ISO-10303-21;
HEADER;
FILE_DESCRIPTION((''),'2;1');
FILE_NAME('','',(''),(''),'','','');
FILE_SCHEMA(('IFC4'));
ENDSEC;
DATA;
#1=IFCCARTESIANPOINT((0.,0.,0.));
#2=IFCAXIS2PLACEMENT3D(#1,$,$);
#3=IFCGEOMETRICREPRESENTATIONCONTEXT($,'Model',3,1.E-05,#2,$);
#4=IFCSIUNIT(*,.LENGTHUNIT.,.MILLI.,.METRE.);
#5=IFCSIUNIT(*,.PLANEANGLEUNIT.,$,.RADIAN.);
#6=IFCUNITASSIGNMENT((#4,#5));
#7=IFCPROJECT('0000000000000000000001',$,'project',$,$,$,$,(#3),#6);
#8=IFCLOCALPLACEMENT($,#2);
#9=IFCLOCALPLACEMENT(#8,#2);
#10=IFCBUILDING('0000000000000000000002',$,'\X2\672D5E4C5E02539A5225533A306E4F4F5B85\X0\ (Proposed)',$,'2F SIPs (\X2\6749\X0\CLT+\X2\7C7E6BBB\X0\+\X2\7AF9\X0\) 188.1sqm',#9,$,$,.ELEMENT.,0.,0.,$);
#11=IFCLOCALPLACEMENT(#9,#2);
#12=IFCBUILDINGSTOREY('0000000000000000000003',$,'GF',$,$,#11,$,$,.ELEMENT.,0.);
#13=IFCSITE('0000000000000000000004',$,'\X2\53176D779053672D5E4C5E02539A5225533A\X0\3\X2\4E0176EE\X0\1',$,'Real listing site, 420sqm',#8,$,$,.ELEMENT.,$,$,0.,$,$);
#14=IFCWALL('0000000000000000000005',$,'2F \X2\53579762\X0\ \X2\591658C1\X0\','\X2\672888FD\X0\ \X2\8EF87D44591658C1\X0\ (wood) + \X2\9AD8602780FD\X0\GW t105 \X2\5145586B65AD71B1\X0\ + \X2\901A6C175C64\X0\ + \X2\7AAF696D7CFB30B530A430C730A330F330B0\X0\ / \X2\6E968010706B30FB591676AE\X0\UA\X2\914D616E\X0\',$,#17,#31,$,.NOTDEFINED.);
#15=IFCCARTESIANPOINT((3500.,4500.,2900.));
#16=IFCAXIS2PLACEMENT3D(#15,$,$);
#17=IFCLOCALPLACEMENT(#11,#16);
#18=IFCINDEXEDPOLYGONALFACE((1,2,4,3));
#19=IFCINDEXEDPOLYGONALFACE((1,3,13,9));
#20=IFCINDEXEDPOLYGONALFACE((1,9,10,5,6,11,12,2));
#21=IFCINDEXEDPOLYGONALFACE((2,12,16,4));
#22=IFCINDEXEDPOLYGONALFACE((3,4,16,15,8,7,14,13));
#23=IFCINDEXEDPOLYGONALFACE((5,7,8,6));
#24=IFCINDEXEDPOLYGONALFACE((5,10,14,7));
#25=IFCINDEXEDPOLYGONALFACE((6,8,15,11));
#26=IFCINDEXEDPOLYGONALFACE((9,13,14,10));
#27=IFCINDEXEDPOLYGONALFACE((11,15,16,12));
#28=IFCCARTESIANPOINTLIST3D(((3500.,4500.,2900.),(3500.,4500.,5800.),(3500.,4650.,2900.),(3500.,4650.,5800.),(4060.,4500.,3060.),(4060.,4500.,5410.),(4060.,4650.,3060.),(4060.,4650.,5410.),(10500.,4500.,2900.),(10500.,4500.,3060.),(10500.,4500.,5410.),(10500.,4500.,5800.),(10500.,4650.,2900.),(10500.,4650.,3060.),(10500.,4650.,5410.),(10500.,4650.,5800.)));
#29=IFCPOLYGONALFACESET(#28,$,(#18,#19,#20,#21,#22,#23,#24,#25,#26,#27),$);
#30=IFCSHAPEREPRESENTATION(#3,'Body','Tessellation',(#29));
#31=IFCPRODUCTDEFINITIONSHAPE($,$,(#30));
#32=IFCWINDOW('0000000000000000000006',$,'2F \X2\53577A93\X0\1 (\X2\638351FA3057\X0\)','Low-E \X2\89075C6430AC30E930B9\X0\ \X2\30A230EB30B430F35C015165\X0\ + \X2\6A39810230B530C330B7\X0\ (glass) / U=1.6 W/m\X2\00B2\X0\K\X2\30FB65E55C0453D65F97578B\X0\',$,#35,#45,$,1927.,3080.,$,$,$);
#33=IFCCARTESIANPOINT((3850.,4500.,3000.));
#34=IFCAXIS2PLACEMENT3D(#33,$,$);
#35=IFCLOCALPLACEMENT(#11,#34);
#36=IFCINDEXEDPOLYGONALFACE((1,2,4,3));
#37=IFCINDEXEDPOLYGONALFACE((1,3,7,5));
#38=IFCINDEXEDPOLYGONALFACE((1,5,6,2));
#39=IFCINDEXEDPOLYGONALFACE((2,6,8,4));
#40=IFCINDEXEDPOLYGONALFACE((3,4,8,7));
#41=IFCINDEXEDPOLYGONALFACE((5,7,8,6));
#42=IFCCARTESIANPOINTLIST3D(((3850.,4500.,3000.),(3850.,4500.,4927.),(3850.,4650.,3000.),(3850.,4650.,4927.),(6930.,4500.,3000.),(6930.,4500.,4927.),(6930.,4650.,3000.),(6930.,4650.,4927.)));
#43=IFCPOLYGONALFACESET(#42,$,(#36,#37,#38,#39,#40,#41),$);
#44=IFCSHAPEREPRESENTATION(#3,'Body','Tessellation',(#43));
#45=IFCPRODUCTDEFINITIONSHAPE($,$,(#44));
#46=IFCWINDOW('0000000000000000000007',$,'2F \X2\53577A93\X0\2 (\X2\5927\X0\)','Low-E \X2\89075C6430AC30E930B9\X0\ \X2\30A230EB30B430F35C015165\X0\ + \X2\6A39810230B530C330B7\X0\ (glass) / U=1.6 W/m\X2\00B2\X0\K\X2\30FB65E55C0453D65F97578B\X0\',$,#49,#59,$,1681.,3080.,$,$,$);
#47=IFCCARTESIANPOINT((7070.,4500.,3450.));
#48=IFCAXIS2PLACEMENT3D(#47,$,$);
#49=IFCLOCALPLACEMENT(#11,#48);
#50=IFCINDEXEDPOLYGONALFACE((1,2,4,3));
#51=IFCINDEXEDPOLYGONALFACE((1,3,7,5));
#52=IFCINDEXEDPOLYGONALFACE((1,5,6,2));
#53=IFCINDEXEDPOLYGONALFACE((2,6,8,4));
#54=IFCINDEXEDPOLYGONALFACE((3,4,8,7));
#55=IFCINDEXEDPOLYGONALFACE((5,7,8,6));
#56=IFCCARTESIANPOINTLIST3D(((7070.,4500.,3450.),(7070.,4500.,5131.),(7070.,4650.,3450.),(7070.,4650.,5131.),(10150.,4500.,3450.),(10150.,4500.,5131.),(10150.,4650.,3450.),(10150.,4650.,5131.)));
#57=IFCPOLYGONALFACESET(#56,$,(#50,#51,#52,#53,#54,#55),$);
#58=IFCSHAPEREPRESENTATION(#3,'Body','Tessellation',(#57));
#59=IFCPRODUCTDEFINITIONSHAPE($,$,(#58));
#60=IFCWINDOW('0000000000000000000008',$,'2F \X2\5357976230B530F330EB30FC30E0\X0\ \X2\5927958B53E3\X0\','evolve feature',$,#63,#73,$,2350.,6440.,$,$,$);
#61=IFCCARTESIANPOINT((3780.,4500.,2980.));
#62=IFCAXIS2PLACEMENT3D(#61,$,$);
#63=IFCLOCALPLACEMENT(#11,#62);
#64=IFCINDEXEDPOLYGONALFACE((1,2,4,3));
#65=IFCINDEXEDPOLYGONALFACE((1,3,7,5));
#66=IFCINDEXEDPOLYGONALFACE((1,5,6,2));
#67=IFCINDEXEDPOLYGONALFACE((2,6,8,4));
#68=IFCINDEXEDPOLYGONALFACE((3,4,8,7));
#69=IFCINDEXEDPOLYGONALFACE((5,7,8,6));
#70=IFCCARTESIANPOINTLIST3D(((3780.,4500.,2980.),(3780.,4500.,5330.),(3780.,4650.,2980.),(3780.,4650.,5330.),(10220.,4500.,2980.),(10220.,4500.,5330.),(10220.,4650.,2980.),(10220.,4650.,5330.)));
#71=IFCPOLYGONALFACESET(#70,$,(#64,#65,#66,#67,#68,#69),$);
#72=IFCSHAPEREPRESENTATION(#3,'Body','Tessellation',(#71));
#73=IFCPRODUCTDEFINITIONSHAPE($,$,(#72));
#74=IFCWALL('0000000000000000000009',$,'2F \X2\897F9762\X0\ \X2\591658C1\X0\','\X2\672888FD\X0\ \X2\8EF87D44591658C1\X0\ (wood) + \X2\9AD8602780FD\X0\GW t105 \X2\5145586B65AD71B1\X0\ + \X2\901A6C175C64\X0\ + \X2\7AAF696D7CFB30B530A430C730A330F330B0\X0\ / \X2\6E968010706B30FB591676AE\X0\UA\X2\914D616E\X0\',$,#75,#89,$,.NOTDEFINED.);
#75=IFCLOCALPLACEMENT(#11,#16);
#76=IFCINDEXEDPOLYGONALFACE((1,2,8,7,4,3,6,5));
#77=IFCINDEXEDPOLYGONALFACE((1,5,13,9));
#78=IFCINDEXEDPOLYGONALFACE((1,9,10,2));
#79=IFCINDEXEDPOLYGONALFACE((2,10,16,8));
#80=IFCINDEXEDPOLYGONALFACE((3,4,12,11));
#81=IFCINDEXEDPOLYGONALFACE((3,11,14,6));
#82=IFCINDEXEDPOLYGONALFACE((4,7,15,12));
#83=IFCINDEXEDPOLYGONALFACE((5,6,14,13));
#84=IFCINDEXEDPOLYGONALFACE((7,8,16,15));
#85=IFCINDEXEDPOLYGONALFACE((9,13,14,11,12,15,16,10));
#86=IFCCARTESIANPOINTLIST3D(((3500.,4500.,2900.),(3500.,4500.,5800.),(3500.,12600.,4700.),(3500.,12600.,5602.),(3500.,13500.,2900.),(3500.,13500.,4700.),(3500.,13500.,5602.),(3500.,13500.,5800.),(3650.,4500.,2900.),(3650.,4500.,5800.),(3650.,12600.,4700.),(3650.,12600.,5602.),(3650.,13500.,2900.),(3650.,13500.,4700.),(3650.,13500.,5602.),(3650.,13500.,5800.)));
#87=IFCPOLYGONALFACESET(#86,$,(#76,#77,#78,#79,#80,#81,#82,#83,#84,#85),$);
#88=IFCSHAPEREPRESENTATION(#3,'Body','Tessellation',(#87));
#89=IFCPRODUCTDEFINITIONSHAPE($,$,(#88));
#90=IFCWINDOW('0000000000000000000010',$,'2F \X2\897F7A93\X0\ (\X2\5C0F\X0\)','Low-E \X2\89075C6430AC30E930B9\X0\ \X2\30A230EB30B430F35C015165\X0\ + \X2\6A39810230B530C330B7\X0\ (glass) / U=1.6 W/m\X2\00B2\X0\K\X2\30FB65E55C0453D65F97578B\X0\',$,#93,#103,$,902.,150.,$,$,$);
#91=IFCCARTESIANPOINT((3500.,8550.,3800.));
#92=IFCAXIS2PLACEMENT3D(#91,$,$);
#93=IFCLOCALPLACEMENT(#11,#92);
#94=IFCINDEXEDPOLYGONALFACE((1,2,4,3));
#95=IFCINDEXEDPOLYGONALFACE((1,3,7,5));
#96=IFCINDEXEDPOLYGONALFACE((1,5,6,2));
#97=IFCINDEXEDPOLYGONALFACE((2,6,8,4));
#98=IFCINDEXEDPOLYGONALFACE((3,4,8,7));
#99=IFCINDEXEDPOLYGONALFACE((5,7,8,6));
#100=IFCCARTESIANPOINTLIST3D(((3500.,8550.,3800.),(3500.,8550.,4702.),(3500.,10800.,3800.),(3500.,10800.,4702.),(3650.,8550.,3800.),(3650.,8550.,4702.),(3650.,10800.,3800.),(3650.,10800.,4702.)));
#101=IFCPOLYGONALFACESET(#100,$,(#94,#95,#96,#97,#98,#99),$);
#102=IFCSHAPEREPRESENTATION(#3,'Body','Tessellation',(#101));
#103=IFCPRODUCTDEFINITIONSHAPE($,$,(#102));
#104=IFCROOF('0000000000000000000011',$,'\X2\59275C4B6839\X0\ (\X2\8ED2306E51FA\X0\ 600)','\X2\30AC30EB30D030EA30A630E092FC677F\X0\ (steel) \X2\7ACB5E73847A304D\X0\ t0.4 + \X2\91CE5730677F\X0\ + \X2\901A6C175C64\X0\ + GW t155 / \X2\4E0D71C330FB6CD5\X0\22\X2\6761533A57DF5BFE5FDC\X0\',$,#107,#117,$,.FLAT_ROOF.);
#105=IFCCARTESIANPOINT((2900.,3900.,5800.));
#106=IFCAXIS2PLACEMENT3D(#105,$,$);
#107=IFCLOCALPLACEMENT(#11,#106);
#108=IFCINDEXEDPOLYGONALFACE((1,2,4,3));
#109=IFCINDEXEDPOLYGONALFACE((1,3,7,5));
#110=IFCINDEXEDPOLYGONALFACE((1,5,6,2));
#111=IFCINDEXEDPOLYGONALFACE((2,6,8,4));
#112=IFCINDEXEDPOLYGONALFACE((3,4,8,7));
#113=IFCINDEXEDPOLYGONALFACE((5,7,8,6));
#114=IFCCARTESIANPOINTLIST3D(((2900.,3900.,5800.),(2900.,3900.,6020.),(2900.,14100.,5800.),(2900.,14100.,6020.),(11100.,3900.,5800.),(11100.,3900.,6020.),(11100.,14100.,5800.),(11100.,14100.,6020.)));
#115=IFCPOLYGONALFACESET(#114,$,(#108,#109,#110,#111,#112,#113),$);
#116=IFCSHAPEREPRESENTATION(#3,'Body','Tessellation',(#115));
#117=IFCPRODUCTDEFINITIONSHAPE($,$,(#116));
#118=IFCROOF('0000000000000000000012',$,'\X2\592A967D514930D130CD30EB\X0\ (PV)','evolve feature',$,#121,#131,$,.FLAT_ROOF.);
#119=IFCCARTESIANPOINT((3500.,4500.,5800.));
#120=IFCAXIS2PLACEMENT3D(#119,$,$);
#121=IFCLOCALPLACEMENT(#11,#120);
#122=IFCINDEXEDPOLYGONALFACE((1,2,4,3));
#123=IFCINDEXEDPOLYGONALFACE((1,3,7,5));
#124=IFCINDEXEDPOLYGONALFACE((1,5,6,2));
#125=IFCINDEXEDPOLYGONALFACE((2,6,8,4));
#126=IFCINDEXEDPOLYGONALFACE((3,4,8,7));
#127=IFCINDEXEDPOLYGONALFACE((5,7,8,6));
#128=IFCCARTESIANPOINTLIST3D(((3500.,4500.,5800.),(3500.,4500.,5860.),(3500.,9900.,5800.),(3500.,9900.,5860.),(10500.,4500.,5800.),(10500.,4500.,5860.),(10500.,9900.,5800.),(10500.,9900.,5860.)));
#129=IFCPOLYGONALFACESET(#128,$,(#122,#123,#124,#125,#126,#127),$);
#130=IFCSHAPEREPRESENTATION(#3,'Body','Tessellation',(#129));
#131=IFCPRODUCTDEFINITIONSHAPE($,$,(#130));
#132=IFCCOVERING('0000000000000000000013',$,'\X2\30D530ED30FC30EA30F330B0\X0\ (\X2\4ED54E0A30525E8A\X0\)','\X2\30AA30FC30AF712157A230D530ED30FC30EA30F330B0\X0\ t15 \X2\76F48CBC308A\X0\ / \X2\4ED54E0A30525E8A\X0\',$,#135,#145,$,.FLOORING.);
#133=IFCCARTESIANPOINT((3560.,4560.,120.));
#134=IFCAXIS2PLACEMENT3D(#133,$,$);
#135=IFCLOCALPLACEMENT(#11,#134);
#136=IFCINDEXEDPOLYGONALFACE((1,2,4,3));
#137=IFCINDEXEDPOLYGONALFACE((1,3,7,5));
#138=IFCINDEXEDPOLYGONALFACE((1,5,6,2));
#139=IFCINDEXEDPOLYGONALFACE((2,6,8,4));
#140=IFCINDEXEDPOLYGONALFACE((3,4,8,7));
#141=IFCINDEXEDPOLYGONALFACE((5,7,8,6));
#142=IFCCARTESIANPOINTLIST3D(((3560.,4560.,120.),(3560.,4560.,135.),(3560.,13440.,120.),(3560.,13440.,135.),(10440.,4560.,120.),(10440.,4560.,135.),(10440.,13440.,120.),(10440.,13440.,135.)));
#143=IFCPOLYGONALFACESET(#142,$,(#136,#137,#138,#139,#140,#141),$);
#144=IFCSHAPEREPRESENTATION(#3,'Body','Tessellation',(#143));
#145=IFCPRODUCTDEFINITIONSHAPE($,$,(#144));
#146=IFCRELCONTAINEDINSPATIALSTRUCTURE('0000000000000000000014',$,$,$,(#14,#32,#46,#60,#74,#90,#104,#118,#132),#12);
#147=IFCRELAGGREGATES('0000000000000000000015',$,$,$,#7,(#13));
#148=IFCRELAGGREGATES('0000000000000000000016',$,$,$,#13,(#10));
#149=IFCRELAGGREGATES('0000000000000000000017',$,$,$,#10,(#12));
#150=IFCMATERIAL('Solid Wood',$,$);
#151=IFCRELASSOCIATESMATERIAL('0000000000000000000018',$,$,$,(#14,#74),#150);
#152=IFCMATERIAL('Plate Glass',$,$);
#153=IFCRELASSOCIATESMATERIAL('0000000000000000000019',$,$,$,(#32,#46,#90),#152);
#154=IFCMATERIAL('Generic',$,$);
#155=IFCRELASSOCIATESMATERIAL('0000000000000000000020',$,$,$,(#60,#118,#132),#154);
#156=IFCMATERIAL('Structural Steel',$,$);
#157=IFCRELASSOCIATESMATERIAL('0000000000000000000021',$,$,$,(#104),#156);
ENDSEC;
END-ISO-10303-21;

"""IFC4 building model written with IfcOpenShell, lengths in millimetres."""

from ifc_helpers import new_model, si_unit, frame, frame_2d, origin, place, context, project, spatial, rectangle, extrude, material, element, fill, save


model = new_model("IFC4")

# Units and contexts
model_context = context("Model", 3, precision=1e-05, world=origin())
ifc_project = project(units=[si_unit("LENGTHUNIT", "METRE", prefix="MILLI"), si_unit("PLANEANGLEUNIT", "RADIAN")], contexts=[model_context])

# Site, building, storey
site_placement = place(None, origin())
site = spatial("IfcSite", under=ifc_project, at=site_placement, Name="北海道札幌市厚別区3丁目1", ObjectType="Real listing site, 420sqm", CompositionType="ELEMENT", RefElevation=0.0)
building_placement = place(site_placement, origin())
building = spatial("IfcBuilding", under=site, at=building_placement, Name="札幌市厚別区の住宅 (Proposed)", ObjectType="2F SIPs (杉CLT+籾殻+竹) 188.1sqm", CompositionType="ELEMENT", ElevationOfRefHeight=0.0, ElevationOfTerrain=0.0)
storey_placement = place(building_placement, origin())
storey = spatial("IfcBuildingStorey", under=building, at=storey_placement, Name="GF", CompositionType="ELEMENT", Elevation=0.0)

# Shared definitions
ifc_material_1 = material(Name="Solid Wood")
ifc_material_2 = material(Name="Generic")

# Shared definitions
ifc_material_3 = material(Name="Plate Glass")

# Wall, openings, windows
wall_1_placement = place(storey_placement, frame((3500.0, 4500.0, 2900.0)))
wall_1 = element("IfcWall", 1, at=wall_1_placement, inside=storey, material=ifc_material_1, Name="2F 南面 外壁", Description="木製 軸組外壁 (wood) + 高性能GW t105 充填断熱 + 通気層 + 窯業系サイディング / 準耐火・外皮UA配慮", PredefinedType="NOTDEFINED", context=model_context, shape_type="SweptSolid", body=[
    extrude(rectangle(XDim=7000.0, YDim=150.0, at=frame_2d((3500.0, 75.0))), frame((3500.0, 4500.0, 2900.0)), (0.0, 0.0, 1.0), 2900.0),
])
opening_1_placement = place(storey_placement, frame((3850.0, 4500.0, 3000.0)))
opening_1 = element("IfcOpeningElement", 2, at=opening_1_placement, cuts=wall_1, PredefinedType="NOTDEFINED", context=model_context, shape_type="SweptSolid", body=[
    extrude(rectangle(XDim=3080.0, YDim=150.0, at=frame_2d((1540.0, 75.0))), frame((3850.0, 4500.0, 3000.0)), (0.0, 0.0, 1.0), 1927.0),
])
opening_2_placement = place(storey_placement, frame((7070.0, 4500.0, 3450.0)))
opening_2 = element("IfcOpeningElement", 3, at=opening_2_placement, cuts=wall_1, PredefinedType="NOTDEFINED", context=model_context, shape_type="SweptSolid", body=[
    extrude(rectangle(XDim=3080.0, YDim=150.0, at=frame_2d((1540.0, 75.0))), frame((7070.0, 4500.0, 3450.0)), (0.0, 0.0, 1.0), 1681.0),
])
opening_3_placement = place(storey_placement, frame((3780.0, 4500.0, 2980.0)))
opening_3 = element("IfcOpeningElement", 4, at=opening_3_placement, cuts=wall_1, PredefinedType="NOTDEFINED", context=model_context, shape_type="SweptSolid", body=[
    extrude(rectangle(XDim=6440.0, YDim=150.0, at=frame_2d((3220.0, 75.0))), frame((3780.0, 4500.0, 2980.0)), (0.0, 0.0, 1.0), 2350.0),
])
window_1_placement = place(storey_placement, frame((3850.0, 4500.0, 3000.0)))
window_1 = element("IfcWindow", 5, at=window_1_placement, inside=storey, material=ifc_material_3, Name="2F 南窓1 (掃出し)", Description="Low-E 複層ガラス アルゴン封入 + 樹脂サッシ (glass) / U=1.6 W/m²K・日射取得型", OverallHeight=1927.0, OverallWidth=3080.0, context=model_context, shape_type="SweptSolid", body=[
    extrude(rectangle(XDim=3080.0, YDim=150.0, at=frame_2d((1540.0, 75.0))), frame((3850.0, 4500.0, 3000.0)), (0.0, 0.0, 1.0), 1927.0),
])
fill(opening_1, window_1)
window_2_placement = place(storey_placement, frame((7070.0, 4500.0, 3450.0)))
window_2 = element("IfcWindow", 6, at=window_2_placement, inside=storey, material=ifc_material_3, Name="2F 南窓2 (大)", Description="Low-E 複層ガラス アルゴン封入 + 樹脂サッシ (glass) / U=1.6 W/m²K・日射取得型", OverallHeight=1681.0, OverallWidth=3080.0, context=model_context, shape_type="SweptSolid", body=[
    extrude(rectangle(XDim=3080.0, YDim=150.0, at=frame_2d((1540.0, 75.0))), frame((7070.0, 4500.0, 3450.0)), (0.0, 0.0, 1.0), 1681.0),
])
fill(opening_2, window_2)
window_3_placement = place(storey_placement, frame((3780.0, 4500.0, 2980.0)))
window_3 = element("IfcWindow", 7, at=window_3_placement, inside=storey, material=ifc_material_2, Name="2F 南面サンルーム 大開口", Description="evolve feature", OverallHeight=2350.0, OverallWidth=6440.0, context=model_context, shape_type="SweptSolid", body=[
    extrude(rectangle(XDim=6440.0, YDim=150.0, at=frame_2d((3220.0, 75.0))), frame((3780.0, 4500.0, 2980.0)), (0.0, 0.0, 1.0), 2350.0),
])
fill(opening_3, window_3)

# Wall, opening, window
wall_2_placement = place(storey_placement, frame((3500.0, 4500.0, 2900.0)))
wall_2 = element("IfcWall", 8, at=wall_2_placement, inside=storey, material=ifc_material_1, Name="2F 西面 外壁", Description="木製 軸組外壁 (wood) + 高性能GW t105 充填断熱 + 通気層 + 窯業系サイディング / 準耐火・外皮UA配慮", PredefinedType="NOTDEFINED", context=model_context, shape_type="SweptSolid", body=[
    extrude(rectangle(XDim=150.0, YDim=9000.0, at=frame_2d((75.0, 4500.0))), frame((3500.0, 4500.0, 2900.0)), (0.0, 0.0, 1.0), 2900.0),
])
opening_4_placement = place(storey_placement, frame((3500.0, 8550.0, 3800.0)))
opening_4 = element("IfcOpeningElement", 9, at=opening_4_placement, cuts=wall_2, PredefinedType="NOTDEFINED", context=model_context, shape_type="SweptSolid", body=[
    extrude(rectangle(XDim=150.0, YDim=2250.0, at=frame_2d((75.0, 1125.0))), frame((3500.0, 8550.0, 3800.0)), (0.0, 0.0, 1.0), 902.0),
])
window_4_placement = place(storey_placement, frame((3500.0, 8550.0, 3800.0)))
window_4 = element("IfcWindow", 10, at=window_4_placement, inside=storey, material=ifc_material_3, Name="2F 西窓 (小)", Description="Low-E 複層ガラス アルゴン封入 + 樹脂サッシ (glass) / U=1.6 W/m²K・日射取得型", OverallHeight=902.0, OverallWidth=150.0, context=model_context, shape_type="SweptSolid", body=[
    extrude(rectangle(XDim=150.0, YDim=2250.0, at=frame_2d((75.0, 1125.0))), frame((3500.0, 8550.0, 3800.0)), (0.0, 0.0, 1.0), 902.0),
])
fill(opening_4, window_4)

# Roofs
ifc_material_4 = material(Name="Structural Steel")
roof_1_placement = place(storey_placement, frame((2900.0, 3900.0, 5800.0)))
element("IfcRoof", 11, at=roof_1_placement, inside=storey, material=ifc_material_4, Name="大屋根 (軒の出 600)", Description="ガルバリウム鋼板 (steel) 立平葺き t0.4 + 野地板 + 通気層 + GW t155 / 不燃・法22条区域対応", PredefinedType="FLAT_ROOF", context=model_context, shape_type="SweptSolid", body=[
    extrude(rectangle(XDim=8200.0, YDim=10200.0, at=frame_2d((4100.0, 5100.0))), frame((2900.0, 3900.0, 5800.0)), (0.0, 0.0, 1.0), 220.0),
])
roof_2_placement = place(storey_placement, frame((3500.0, 4500.0, 5800.0)))
element("IfcRoof", 12, at=roof_2_placement, inside=storey, material=ifc_material_2, Name="太陽光パネル (PV)", Description="evolve feature", PredefinedType="FLAT_ROOF", context=model_context, shape_type="SweptSolid", body=[
    extrude(rectangle(XDim=7000.0, YDim=5400.0, at=frame_2d((3500.0, 2700.0))), frame((3500.0, 4500.0, 5800.0)), (0.0, 0.0, 1.0), 60.0),
])

# Covering
covering_placement = place(storey_placement, frame((3560.0, 4560.0, 120.0)))
element("IfcCovering", 13, at=covering_placement, inside=storey, material=ifc_material_2, Name="フローリング (仕上げ床)", Description="オーク無垢フローリング t15 直貼り / 仕上げ床", PredefinedType="FLOORING", context=model_context, shape_type="SweptSolid", body=[
    extrude(rectangle(XDim=6880.0, YDim=8880.0, at=frame_2d((3440.0, 4440.0))), frame((3560.0, 4560.0, 120.0)), (0.0, 0.0, 1.0), 15.0),
])

save(model, "model.ifc")
